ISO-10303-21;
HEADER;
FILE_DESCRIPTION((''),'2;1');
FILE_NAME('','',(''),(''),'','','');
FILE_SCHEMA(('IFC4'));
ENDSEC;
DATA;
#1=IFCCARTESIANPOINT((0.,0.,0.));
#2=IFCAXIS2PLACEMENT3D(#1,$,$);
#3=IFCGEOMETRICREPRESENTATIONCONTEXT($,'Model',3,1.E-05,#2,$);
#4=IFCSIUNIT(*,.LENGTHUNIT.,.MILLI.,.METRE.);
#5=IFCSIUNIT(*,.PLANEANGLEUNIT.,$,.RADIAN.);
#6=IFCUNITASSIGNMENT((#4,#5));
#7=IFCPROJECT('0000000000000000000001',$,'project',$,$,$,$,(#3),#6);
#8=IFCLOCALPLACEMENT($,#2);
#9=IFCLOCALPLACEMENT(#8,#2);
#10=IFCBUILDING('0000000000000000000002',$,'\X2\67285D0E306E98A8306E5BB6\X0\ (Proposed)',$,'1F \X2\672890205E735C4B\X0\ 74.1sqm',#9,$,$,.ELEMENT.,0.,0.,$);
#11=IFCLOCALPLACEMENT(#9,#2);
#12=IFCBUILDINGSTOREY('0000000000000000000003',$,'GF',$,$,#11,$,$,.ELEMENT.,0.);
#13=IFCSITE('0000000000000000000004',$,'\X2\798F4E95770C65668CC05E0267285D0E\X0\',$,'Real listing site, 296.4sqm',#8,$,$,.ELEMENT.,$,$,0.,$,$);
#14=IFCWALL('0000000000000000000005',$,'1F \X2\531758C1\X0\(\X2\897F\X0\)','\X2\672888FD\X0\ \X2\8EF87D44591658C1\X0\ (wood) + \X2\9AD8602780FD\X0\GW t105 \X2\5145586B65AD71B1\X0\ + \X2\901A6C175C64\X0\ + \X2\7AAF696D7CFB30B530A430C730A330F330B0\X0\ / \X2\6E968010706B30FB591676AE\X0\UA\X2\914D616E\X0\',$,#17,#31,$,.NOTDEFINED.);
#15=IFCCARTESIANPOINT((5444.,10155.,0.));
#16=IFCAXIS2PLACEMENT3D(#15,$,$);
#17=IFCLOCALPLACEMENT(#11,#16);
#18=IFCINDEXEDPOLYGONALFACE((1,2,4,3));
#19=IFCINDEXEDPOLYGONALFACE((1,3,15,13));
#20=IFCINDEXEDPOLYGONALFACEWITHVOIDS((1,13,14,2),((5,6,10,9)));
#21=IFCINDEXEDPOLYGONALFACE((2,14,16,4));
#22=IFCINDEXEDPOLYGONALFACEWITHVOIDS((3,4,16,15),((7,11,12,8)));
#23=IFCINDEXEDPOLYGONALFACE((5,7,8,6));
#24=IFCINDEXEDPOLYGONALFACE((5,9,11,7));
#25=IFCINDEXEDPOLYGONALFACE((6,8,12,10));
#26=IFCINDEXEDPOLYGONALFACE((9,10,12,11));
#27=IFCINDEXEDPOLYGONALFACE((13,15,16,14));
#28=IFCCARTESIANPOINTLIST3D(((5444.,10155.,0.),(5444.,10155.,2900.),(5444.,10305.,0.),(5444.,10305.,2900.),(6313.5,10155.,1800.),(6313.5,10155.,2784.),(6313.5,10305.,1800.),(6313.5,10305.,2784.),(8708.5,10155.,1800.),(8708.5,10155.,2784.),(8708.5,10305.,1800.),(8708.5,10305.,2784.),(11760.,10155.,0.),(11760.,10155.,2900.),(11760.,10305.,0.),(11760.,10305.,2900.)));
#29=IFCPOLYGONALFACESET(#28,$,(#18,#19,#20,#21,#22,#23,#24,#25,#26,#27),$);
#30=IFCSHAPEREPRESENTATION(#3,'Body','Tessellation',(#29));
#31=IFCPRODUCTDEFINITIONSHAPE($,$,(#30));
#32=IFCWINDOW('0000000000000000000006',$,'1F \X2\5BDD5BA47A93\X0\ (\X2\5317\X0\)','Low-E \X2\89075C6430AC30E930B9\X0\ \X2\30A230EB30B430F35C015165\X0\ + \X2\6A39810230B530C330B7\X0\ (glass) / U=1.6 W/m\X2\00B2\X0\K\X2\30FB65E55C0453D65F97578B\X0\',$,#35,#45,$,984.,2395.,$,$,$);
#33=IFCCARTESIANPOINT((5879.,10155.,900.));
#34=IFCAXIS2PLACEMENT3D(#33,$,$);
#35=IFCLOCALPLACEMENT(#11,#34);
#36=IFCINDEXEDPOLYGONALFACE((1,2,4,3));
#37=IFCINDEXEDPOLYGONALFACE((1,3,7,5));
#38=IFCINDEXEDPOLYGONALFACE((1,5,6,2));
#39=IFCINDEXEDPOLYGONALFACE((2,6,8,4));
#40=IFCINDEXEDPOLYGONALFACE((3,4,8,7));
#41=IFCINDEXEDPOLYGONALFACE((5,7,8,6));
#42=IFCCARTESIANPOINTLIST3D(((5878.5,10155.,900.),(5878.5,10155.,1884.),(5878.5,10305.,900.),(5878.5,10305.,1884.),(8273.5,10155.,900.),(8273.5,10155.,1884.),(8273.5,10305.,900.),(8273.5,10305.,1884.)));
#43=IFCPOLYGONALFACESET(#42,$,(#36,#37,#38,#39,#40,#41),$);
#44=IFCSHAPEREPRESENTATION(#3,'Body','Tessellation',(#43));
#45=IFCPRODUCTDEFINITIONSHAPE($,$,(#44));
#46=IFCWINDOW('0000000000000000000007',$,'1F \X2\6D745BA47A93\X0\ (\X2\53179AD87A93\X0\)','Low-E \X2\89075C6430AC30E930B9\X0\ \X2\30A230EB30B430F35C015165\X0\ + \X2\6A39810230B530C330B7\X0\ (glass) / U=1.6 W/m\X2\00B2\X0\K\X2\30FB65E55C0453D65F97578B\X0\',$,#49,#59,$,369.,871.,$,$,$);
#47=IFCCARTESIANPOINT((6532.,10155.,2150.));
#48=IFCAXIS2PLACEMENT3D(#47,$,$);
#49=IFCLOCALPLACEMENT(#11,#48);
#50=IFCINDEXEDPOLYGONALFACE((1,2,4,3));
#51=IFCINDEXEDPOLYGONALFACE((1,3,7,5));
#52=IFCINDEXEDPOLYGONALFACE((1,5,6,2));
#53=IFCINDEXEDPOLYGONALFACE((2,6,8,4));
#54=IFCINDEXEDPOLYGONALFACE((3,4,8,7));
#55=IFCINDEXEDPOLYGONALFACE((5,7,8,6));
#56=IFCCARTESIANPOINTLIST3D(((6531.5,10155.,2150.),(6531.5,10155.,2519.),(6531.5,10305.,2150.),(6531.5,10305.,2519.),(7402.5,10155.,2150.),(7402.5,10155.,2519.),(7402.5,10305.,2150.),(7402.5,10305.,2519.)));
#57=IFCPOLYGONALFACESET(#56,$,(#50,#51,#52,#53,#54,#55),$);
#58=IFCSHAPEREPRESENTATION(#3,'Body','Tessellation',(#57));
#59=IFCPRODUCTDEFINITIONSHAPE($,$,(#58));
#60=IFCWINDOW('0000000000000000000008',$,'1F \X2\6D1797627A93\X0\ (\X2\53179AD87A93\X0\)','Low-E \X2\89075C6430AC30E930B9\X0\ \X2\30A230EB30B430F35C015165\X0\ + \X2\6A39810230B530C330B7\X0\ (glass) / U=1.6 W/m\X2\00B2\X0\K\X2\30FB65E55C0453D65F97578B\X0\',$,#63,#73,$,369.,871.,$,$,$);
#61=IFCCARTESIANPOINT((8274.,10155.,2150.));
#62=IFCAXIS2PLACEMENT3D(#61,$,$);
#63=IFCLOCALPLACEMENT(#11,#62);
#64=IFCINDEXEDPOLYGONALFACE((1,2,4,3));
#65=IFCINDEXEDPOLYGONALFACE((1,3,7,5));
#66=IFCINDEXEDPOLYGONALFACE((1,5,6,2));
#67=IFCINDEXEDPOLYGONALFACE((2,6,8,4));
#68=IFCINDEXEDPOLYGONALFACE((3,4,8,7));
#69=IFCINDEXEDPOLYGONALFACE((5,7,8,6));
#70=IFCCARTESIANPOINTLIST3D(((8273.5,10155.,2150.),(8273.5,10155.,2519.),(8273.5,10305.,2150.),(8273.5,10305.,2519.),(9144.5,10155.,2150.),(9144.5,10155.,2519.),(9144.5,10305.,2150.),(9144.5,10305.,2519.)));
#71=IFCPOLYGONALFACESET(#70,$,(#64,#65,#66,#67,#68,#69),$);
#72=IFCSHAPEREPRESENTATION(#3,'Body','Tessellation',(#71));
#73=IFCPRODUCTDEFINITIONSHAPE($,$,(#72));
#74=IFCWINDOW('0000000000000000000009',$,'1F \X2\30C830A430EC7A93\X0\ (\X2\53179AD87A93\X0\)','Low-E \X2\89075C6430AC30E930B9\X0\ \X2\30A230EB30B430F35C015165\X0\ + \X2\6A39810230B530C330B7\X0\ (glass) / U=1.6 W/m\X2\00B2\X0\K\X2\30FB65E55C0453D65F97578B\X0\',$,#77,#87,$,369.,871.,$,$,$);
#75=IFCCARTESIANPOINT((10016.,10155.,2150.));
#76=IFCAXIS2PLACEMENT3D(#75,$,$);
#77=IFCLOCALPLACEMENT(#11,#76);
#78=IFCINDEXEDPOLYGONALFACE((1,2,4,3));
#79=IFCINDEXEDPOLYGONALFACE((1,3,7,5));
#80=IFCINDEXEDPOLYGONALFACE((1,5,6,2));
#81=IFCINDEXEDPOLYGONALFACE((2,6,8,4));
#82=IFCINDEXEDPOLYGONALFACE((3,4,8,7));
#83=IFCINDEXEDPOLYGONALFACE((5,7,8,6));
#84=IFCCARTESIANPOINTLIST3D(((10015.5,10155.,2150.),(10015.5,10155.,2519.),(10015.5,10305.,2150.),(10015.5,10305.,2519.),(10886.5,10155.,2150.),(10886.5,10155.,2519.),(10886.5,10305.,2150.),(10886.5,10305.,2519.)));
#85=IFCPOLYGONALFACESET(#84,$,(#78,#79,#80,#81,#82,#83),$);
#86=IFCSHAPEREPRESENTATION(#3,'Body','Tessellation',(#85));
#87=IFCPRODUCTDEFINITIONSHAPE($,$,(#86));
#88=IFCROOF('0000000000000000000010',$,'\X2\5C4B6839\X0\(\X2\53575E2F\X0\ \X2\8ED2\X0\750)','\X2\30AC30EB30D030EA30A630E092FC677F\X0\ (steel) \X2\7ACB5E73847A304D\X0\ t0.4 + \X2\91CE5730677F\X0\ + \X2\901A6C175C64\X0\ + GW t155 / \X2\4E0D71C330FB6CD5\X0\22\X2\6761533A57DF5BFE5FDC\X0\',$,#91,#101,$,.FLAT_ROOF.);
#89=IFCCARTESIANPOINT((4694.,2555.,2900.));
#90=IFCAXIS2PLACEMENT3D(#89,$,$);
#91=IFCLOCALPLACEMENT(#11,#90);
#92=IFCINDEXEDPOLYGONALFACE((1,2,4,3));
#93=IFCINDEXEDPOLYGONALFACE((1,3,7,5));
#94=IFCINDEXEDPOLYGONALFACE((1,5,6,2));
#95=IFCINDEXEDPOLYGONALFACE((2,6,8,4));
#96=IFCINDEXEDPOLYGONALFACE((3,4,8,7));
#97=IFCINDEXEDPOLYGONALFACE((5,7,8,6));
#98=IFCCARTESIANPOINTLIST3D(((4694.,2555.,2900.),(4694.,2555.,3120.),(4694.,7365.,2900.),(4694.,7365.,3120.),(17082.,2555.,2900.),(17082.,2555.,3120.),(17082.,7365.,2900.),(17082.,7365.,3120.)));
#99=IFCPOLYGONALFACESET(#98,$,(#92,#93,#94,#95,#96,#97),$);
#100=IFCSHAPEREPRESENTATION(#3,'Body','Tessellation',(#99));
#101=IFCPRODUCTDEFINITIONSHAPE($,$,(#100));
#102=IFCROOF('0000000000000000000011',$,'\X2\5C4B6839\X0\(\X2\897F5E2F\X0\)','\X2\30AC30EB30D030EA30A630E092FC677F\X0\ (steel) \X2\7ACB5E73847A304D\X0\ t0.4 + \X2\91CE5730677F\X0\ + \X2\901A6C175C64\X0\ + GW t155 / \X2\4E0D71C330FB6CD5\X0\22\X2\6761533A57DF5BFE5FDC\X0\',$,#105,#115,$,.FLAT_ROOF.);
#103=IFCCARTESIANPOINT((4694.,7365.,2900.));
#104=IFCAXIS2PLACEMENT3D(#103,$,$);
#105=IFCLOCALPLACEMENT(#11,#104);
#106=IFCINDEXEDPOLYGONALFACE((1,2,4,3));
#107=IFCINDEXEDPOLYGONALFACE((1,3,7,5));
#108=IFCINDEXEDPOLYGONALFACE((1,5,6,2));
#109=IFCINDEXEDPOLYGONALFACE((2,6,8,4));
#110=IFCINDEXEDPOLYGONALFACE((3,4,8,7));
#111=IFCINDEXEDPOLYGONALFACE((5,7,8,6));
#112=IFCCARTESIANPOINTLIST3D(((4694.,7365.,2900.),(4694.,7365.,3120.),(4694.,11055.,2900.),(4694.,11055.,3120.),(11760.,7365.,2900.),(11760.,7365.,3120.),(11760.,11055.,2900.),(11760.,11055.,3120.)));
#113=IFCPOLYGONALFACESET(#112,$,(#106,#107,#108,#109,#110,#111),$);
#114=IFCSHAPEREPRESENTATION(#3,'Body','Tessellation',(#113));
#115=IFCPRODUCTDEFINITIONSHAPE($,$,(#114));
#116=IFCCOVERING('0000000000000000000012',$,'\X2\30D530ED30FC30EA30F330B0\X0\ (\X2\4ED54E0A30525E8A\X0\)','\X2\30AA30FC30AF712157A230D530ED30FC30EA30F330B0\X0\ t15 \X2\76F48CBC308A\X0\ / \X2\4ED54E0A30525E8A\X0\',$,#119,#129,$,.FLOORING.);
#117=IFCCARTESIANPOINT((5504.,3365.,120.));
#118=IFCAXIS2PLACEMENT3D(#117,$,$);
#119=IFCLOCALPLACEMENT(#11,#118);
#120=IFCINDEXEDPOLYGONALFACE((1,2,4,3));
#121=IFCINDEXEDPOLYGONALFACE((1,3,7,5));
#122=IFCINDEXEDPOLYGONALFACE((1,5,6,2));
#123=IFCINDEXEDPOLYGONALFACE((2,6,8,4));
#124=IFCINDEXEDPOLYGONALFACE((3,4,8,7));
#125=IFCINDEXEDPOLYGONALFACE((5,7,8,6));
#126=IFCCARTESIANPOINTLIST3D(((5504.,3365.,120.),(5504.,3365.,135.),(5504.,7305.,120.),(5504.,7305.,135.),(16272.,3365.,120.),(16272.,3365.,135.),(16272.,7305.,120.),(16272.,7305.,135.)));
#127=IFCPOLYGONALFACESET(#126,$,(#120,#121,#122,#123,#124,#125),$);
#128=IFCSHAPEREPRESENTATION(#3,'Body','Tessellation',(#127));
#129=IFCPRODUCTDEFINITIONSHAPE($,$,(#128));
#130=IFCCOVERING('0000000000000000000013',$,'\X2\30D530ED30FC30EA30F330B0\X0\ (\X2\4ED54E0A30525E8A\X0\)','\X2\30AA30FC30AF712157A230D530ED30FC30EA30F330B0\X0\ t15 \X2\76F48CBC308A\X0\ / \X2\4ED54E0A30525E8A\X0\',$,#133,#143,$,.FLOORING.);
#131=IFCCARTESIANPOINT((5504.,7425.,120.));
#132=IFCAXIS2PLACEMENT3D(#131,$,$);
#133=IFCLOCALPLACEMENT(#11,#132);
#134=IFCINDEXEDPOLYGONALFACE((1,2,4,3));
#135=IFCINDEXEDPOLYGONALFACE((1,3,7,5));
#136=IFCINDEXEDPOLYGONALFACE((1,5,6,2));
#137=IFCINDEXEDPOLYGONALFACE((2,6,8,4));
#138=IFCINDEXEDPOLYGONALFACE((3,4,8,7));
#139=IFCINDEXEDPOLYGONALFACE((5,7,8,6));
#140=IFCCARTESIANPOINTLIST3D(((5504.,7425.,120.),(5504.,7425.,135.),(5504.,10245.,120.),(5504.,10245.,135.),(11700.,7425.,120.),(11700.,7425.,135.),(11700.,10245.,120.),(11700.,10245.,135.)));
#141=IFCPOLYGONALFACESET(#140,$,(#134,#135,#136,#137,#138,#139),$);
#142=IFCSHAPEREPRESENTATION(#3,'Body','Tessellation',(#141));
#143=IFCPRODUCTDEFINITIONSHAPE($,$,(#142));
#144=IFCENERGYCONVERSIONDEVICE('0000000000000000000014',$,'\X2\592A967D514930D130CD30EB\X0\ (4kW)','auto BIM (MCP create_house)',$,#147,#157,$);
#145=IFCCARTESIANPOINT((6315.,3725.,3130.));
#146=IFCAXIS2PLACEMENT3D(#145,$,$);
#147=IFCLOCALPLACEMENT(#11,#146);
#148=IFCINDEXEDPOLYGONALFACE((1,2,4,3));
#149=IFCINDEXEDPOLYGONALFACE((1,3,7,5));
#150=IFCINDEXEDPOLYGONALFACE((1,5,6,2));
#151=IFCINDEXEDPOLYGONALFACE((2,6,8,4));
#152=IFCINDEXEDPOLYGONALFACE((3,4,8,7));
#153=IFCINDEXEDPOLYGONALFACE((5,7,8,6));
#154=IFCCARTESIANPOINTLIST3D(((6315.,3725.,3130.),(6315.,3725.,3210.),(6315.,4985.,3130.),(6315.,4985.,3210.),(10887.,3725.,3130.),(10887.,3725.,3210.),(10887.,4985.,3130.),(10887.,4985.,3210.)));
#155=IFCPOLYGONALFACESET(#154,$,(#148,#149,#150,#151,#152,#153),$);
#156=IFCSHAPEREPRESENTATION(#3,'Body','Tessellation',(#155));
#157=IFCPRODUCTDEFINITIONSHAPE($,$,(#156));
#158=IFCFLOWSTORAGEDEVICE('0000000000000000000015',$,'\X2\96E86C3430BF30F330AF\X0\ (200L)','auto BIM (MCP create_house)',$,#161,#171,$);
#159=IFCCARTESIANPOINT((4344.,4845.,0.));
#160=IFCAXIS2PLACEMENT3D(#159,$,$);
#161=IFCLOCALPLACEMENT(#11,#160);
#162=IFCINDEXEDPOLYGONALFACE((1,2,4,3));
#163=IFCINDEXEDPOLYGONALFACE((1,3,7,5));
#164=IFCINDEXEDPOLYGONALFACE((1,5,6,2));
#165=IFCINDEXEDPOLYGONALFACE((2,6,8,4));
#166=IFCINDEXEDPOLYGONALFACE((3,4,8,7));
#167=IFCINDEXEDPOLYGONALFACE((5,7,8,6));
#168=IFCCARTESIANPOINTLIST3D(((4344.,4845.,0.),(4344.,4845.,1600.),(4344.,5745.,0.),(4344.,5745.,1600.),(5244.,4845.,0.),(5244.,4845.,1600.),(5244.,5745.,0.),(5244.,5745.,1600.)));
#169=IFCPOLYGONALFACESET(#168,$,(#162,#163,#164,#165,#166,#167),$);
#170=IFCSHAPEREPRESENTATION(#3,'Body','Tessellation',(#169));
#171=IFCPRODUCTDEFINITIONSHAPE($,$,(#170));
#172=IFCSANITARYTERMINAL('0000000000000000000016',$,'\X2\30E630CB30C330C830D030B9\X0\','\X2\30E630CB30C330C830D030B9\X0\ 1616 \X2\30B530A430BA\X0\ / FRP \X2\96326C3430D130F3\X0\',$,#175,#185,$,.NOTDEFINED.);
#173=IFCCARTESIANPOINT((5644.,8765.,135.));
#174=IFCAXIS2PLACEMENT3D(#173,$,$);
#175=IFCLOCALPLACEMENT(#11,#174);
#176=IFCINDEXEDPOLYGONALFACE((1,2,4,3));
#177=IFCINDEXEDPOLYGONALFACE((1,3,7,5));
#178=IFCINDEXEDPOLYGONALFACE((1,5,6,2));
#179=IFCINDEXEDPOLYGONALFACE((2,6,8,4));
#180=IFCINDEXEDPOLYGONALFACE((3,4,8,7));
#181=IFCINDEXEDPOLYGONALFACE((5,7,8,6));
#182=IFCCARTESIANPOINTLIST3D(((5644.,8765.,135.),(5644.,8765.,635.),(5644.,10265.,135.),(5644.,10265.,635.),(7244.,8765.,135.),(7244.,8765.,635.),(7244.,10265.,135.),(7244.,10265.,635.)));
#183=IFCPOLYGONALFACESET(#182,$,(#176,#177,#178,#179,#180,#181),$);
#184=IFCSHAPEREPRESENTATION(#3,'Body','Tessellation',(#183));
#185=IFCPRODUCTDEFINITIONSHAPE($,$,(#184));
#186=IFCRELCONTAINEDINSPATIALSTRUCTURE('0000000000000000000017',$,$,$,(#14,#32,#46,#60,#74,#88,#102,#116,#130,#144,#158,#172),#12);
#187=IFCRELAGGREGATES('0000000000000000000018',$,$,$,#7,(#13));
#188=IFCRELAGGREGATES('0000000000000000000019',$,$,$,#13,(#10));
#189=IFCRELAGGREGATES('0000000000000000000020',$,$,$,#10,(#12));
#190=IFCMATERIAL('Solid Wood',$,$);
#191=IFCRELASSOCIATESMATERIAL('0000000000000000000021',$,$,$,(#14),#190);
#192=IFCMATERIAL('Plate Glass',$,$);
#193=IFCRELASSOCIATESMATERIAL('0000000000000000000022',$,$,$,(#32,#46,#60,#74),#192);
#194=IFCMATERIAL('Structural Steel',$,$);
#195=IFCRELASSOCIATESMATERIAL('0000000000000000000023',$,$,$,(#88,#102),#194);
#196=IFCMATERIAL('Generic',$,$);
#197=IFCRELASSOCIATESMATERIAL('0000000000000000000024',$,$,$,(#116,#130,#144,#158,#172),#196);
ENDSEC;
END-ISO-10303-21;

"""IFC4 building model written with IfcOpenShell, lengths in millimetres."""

from ifc_helpers import new_model, si_unit, frame, frame_2d, origin, place, context, project, spatial, rectangle, extrude, material, element, fill, save


model = new_model("IFC4")

# Units and contexts
model_context = context("Model", 3, precision=1e-05, world=origin())
ifc_project = project(units=[si_unit("LENGTHUNIT", "METRE", prefix="MILLI"), si_unit("PLANEANGLEUNIT", "RADIAN")], contexts=[model_context])

# Site, building, storey
site_placement = place(None, origin())
site = spatial("IfcSite", under=ifc_project, at=site_placement, Name="福井県敦賀市木崎", ObjectType="Real listing site, 296.4sqm", CompositionType="ELEMENT", RefElevation=0.0)
building_placement = place(site_placement, origin())
building = spatial("IfcBuilding", under=site, at=building_placement, Name="木崎の風の家 (Proposed)", ObjectType="1F 木造平屋 74.1sqm", CompositionType="ELEMENT", ElevationOfRefHeight=0.0, ElevationOfTerrain=0.0)
storey_placement = place(building_placement, origin())
storey = spatial("IfcBuildingStorey", under=building, at=storey_placement, Name="GF", CompositionType="ELEMENT", Elevation=0.0)

# Shared definitions
ifc_material_1 = material(Name="Solid Wood")

# Shared definitions
ifc_material_2 = material(Name="Plate Glass")

# Wall, openings, windows
wall_1_placement = place(storey_placement, frame((5444.0, 10155.0, 0.0)))
wall_1 = element("IfcWall", 1, at=wall_1_placement, inside=storey, material=ifc_material_1, Name="1F 北壁(西)", Description="木製 軸組外壁 (wood) + 高性能GW t105 充填断熱 + 通気層 + 窯業系サイディング / 準耐火・外皮UA配慮", PredefinedType="NOTDEFINED", context=model_context, shape_type="SweptSolid", body=[
    extrude(rectangle(XDim=6316.0, YDim=150.0, at=frame_2d((3158.0, 75.0))), frame((5444.0, 10155.0, 0.0)), (0.0, 0.0, 1.0), 2900.0),
])
opening_1_placement = place(storey_placement, frame((5879.0, 10155.0, 900.0)))
opening_1 = element("IfcOpeningElement", 2, at=opening_1_placement, cuts=wall_1, PredefinedType="NOTDEFINED", context=model_context, shape_type="SweptSolid", body=[
    extrude(rectangle(XDim=2395.0, YDim=150.0, at=frame_2d((1197.0, 75.0))), frame((5879.0, 10155.0, 900.0)), (0.0, 0.0, 1.0), 984.0),
])
opening_2_placement = place(storey_placement, frame((6532.0, 10155.0, 2150.0)))
opening_2 = element("IfcOpeningElement", 3, at=opening_2_placement, cuts=wall_1, PredefinedType="NOTDEFINED", context=model_context, shape_type="SweptSolid", body=[
    extrude(rectangle(XDim=871.0, YDim=150.0, at=frame_2d((435.0, 75.0))), frame((6532.0, 10155.0, 2150.0)), (0.0, 0.0, 1.0), 369.0),
])
opening_3_placement = place(storey_placement, frame((8274.0, 10155.0, 2150.0)))
opening_3 = element("IfcOpeningElement", 4, at=opening_3_placement, cuts=wall_1, PredefinedType="NOTDEFINED", context=model_context, shape_type="SweptSolid", body=[
    extrude(rectangle(XDim=871.0, YDim=150.0, at=frame_2d((435.0, 75.0))), frame((8274.0, 10155.0, 2150.0)), (0.0, 0.0, 1.0), 369.0),
])
opening_4_placement = place(storey_placement, frame((10016.0, 10155.0, 2150.0)))
opening_4 = element("IfcOpeningElement", 5, at=opening_4_placement, cuts=wall_1, PredefinedType="NOTDEFINED", context=model_context, shape_type="SweptSolid", body=[
    extrude(rectangle(XDim=871.0, YDim=150.0, at=frame_2d((435.0, 75.0))), frame((10016.0, 10155.0, 2150.0)), (0.0, 0.0, 1.0), 369.0),
])
window_1_placement = place(storey_placement, frame((5879.0, 10155.0, 900.0)))
window_1 = element("IfcWindow", 6, at=window_1_placement, inside=storey, material=ifc_material_2, Name="1F 寝室窓 (北)", Description="Low-E 複層ガラス アルゴン封入 + 樹脂サッシ (glass) / U=1.6 W/m²K・日射取得型", OverallHeight=984.0, OverallWidth=2395.0, context=model_context, shape_type="SweptSolid", body=[
    extrude(rectangle(XDim=2395.0, YDim=150.0, at=frame_2d((1197.0, 75.0))), frame((5879.0, 10155.0, 900.0)), (0.0, 0.0, 1.0), 984.0),
])
fill(opening_1, window_1)
window_2_placement = place(storey_placement, frame((6532.0, 10155.0, 2150.0)))
window_2 = element("IfcWindow", 7, at=window_2_placement, inside=storey, material=ifc_material_2, Name="1F 浴室窓 (北高窓)", Description="Low-E 複層ガラス アルゴン封入 + 樹脂サッシ (glass) / U=1.6 W/m²K・日射取得型", OverallHeight=369.0, OverallWidth=871.0, context=model_context, shape_type="SweptSolid", body=[
    extrude(rectangle(XDim=871.0, YDim=150.0, at=frame_2d((435.0, 75.0))), frame((6532.0, 10155.0, 2150.0)), (0.0, 0.0, 1.0), 369.0),
])
fill(opening_2, window_2)
window_3_placement = place(storey_placement, frame((8274.0, 10155.0, 2150.0)))
window_3 = element("IfcWindow", 8, at=window_3_placement, inside=storey, material=ifc_material_2, Name="1F 洗面窓 (北高窓)", Description="Low-E 複層ガラス アルゴン封入 + 樹脂サッシ (glass) / U=1.6 W/m²K・日射取得型", OverallHeight=369.0, OverallWidth=871.0, context=model_context, shape_type="SweptSolid", body=[
    extrude(rectangle(XDim=871.0, YDim=150.0, at=frame_2d((435.0, 75.0))), frame((8274.0, 10155.0, 2150.0)), (0.0, 0.0, 1.0), 369.0),
])
fill(opening_3, window_3)
window_4_placement = place(storey_placement, frame((10016.0, 10155.0, 2150.0)))
window_4 = element("IfcWindow", 9, at=window_4_placement, inside=storey, material=ifc_material_2, Name="1F トイレ窓 (北高窓)", Description="Low-E 複層ガラス アルゴン封入 + 樹脂サッシ (glass) / U=1.6 W/m²K・日射取得型", OverallHeight=369.0, OverallWidth=871.0, context=model_context, shape_type="SweptSolid", body=[
    extrude(rectangle(XDim=871.0, YDim=150.0, at=frame_2d((435.0, 75.0))), frame((10016.0, 10155.0, 2150.0)), (0.0, 0.0, 1.0), 369.0),
])
fill(opening_4, window_4)

# Roofs
ifc_material_3 = material(Name="Structural Steel")
roof_1_placement = place(storey_placement, frame((4694.0, 2555.0, 2900.0)))
element("IfcRoof", 10, at=roof_1_placement, inside=storey, material=ifc_material_3, Name="屋根(南帯 軒750)", Description="ガルバリウム鋼板 (steel) 立平葺き t0.4 + 野地板 + 通気層 + GW t155 / 不燃・法22条区域対応", PredefinedType="FLAT_ROOF", context=model_context, shape_type="SweptSolid", body=[
    extrude(rectangle(XDim=12388.0, YDim=4810.0, at=frame_2d((6194.0, 2405.0))), frame((4694.0, 2555.0, 2900.0)), (0.0, 0.0, 1.0), 220.0),
])
roof_2_placement = place(storey_placement, frame((4694.0, 7365.0, 2900.0)))
element("IfcRoof", 11, at=roof_2_placement, inside=storey, material=ifc_material_3, Name="屋根(西帯)", Description="ガルバリウム鋼板 (steel) 立平葺き t0.4 + 野地板 + 通気層 + GW t155 / 不燃・法22条区域対応", PredefinedType="FLAT_ROOF", context=model_context, shape_type="SweptSolid", body=[
    extrude(rectangle(XDim=7066.0, YDim=3690.0, at=frame_2d((3533.0, 1845.0))), frame((4694.0, 7365.0, 2900.0)), (0.0, 0.0, 1.0), 220.0),
])

# Coverings
ifc_material_4 = material(Name="Generic")
covering_1_placement = place(storey_placement, frame((5504.0, 3365.0, 120.0)))
element("IfcCovering", 12, at=covering_1_placement, inside=storey, material=ifc_material_4, Name="フローリング (仕上げ床)", Description="オーク無垢フローリング t15 直貼り / 仕上げ床", PredefinedType="FLOORING", context=model_context, shape_type="SweptSolid", body=[
    extrude(rectangle(XDim=10768.0, YDim=3940.0, at=frame_2d((5384.0, 1970.0))), frame((5504.0, 3365.0, 120.0)), (0.0, 0.0, 1.0), 15.0),
])
covering_2_placement = place(storey_placement, frame((5504.0, 7425.0, 120.0)))
element("IfcCovering", 13, at=covering_2_placement, inside=storey, material=ifc_material_4, Name="フローリング (仕上げ床)", Description="オーク無垢フローリング t15 直貼り / 仕上げ床", PredefinedType="FLOORING", context=model_context, shape_type="SweptSolid", body=[
    extrude(rectangle(XDim=6196.0, YDim=2820.0, at=frame_2d((3098.0, 1410.0))), frame((5504.0, 7425.0, 120.0)), (0.0, 0.0, 1.0), 15.0),
])

# Energy conversion device
energy_conversion_device_placement = place(storey_placement, frame((6315.0, 3725.0, 3130.0)))
element("IfcEnergyConversionDevice", 14, at=energy_conversion_device_placement, inside=storey, material=ifc_material_4, Name="太陽光パネル (4kW)", Description="auto BIM (MCP create_house)", context=model_context, shape_type="SweptSolid", body=[
    extrude(rectangle(XDim=4572.0, YDim=1260.0, at=frame_2d((2286.0, 630.0))), frame((6315.0, 3725.0, 3130.0)), (0.0, 0.0, 1.0), 80.0),
])

# Flow storage device
flow_storage_device_placement = place(storey_placement, frame((4344.0, 4845.0, 0.0)))
element("IfcFlowStorageDevice", 15, at=flow_storage_device_placement, inside=storey, material=ifc_material_4, Name="雨水タンク (200L)", Description="auto BIM (MCP create_house)", context=model_context, shape_type="SweptSolid", body=[
    extrude(rectangle(XDim=900.0, YDim=900.0, at=frame_2d((450.0, 450.0))), frame((4344.0, 4845.0, 0.0)), (0.0, 0.0, 1.0), 1600.0),
])

# Sanitary terminal
sanitary_terminal_placement = place(storey_placement, frame((5644.0, 8765.0, 135.0)))
element("IfcSanitaryTerminal", 16, at=sanitary_terminal_placement, inside=storey, material=ifc_material_4, Name="ユニットバス", Description="ユニットバス 1616 サイズ / FRP 防水パン", PredefinedType="NOTDEFINED", context=model_context, shape_type="SweptSolid", body=[
    extrude(rectangle(XDim=1600.0, YDim=1500.0, at=frame_2d((800.0, 750.0))), frame((5644.0, 8765.0, 135.0)), (0.0, 0.0, 1.0), 500.0),
])

save(model, "model.ifc")
